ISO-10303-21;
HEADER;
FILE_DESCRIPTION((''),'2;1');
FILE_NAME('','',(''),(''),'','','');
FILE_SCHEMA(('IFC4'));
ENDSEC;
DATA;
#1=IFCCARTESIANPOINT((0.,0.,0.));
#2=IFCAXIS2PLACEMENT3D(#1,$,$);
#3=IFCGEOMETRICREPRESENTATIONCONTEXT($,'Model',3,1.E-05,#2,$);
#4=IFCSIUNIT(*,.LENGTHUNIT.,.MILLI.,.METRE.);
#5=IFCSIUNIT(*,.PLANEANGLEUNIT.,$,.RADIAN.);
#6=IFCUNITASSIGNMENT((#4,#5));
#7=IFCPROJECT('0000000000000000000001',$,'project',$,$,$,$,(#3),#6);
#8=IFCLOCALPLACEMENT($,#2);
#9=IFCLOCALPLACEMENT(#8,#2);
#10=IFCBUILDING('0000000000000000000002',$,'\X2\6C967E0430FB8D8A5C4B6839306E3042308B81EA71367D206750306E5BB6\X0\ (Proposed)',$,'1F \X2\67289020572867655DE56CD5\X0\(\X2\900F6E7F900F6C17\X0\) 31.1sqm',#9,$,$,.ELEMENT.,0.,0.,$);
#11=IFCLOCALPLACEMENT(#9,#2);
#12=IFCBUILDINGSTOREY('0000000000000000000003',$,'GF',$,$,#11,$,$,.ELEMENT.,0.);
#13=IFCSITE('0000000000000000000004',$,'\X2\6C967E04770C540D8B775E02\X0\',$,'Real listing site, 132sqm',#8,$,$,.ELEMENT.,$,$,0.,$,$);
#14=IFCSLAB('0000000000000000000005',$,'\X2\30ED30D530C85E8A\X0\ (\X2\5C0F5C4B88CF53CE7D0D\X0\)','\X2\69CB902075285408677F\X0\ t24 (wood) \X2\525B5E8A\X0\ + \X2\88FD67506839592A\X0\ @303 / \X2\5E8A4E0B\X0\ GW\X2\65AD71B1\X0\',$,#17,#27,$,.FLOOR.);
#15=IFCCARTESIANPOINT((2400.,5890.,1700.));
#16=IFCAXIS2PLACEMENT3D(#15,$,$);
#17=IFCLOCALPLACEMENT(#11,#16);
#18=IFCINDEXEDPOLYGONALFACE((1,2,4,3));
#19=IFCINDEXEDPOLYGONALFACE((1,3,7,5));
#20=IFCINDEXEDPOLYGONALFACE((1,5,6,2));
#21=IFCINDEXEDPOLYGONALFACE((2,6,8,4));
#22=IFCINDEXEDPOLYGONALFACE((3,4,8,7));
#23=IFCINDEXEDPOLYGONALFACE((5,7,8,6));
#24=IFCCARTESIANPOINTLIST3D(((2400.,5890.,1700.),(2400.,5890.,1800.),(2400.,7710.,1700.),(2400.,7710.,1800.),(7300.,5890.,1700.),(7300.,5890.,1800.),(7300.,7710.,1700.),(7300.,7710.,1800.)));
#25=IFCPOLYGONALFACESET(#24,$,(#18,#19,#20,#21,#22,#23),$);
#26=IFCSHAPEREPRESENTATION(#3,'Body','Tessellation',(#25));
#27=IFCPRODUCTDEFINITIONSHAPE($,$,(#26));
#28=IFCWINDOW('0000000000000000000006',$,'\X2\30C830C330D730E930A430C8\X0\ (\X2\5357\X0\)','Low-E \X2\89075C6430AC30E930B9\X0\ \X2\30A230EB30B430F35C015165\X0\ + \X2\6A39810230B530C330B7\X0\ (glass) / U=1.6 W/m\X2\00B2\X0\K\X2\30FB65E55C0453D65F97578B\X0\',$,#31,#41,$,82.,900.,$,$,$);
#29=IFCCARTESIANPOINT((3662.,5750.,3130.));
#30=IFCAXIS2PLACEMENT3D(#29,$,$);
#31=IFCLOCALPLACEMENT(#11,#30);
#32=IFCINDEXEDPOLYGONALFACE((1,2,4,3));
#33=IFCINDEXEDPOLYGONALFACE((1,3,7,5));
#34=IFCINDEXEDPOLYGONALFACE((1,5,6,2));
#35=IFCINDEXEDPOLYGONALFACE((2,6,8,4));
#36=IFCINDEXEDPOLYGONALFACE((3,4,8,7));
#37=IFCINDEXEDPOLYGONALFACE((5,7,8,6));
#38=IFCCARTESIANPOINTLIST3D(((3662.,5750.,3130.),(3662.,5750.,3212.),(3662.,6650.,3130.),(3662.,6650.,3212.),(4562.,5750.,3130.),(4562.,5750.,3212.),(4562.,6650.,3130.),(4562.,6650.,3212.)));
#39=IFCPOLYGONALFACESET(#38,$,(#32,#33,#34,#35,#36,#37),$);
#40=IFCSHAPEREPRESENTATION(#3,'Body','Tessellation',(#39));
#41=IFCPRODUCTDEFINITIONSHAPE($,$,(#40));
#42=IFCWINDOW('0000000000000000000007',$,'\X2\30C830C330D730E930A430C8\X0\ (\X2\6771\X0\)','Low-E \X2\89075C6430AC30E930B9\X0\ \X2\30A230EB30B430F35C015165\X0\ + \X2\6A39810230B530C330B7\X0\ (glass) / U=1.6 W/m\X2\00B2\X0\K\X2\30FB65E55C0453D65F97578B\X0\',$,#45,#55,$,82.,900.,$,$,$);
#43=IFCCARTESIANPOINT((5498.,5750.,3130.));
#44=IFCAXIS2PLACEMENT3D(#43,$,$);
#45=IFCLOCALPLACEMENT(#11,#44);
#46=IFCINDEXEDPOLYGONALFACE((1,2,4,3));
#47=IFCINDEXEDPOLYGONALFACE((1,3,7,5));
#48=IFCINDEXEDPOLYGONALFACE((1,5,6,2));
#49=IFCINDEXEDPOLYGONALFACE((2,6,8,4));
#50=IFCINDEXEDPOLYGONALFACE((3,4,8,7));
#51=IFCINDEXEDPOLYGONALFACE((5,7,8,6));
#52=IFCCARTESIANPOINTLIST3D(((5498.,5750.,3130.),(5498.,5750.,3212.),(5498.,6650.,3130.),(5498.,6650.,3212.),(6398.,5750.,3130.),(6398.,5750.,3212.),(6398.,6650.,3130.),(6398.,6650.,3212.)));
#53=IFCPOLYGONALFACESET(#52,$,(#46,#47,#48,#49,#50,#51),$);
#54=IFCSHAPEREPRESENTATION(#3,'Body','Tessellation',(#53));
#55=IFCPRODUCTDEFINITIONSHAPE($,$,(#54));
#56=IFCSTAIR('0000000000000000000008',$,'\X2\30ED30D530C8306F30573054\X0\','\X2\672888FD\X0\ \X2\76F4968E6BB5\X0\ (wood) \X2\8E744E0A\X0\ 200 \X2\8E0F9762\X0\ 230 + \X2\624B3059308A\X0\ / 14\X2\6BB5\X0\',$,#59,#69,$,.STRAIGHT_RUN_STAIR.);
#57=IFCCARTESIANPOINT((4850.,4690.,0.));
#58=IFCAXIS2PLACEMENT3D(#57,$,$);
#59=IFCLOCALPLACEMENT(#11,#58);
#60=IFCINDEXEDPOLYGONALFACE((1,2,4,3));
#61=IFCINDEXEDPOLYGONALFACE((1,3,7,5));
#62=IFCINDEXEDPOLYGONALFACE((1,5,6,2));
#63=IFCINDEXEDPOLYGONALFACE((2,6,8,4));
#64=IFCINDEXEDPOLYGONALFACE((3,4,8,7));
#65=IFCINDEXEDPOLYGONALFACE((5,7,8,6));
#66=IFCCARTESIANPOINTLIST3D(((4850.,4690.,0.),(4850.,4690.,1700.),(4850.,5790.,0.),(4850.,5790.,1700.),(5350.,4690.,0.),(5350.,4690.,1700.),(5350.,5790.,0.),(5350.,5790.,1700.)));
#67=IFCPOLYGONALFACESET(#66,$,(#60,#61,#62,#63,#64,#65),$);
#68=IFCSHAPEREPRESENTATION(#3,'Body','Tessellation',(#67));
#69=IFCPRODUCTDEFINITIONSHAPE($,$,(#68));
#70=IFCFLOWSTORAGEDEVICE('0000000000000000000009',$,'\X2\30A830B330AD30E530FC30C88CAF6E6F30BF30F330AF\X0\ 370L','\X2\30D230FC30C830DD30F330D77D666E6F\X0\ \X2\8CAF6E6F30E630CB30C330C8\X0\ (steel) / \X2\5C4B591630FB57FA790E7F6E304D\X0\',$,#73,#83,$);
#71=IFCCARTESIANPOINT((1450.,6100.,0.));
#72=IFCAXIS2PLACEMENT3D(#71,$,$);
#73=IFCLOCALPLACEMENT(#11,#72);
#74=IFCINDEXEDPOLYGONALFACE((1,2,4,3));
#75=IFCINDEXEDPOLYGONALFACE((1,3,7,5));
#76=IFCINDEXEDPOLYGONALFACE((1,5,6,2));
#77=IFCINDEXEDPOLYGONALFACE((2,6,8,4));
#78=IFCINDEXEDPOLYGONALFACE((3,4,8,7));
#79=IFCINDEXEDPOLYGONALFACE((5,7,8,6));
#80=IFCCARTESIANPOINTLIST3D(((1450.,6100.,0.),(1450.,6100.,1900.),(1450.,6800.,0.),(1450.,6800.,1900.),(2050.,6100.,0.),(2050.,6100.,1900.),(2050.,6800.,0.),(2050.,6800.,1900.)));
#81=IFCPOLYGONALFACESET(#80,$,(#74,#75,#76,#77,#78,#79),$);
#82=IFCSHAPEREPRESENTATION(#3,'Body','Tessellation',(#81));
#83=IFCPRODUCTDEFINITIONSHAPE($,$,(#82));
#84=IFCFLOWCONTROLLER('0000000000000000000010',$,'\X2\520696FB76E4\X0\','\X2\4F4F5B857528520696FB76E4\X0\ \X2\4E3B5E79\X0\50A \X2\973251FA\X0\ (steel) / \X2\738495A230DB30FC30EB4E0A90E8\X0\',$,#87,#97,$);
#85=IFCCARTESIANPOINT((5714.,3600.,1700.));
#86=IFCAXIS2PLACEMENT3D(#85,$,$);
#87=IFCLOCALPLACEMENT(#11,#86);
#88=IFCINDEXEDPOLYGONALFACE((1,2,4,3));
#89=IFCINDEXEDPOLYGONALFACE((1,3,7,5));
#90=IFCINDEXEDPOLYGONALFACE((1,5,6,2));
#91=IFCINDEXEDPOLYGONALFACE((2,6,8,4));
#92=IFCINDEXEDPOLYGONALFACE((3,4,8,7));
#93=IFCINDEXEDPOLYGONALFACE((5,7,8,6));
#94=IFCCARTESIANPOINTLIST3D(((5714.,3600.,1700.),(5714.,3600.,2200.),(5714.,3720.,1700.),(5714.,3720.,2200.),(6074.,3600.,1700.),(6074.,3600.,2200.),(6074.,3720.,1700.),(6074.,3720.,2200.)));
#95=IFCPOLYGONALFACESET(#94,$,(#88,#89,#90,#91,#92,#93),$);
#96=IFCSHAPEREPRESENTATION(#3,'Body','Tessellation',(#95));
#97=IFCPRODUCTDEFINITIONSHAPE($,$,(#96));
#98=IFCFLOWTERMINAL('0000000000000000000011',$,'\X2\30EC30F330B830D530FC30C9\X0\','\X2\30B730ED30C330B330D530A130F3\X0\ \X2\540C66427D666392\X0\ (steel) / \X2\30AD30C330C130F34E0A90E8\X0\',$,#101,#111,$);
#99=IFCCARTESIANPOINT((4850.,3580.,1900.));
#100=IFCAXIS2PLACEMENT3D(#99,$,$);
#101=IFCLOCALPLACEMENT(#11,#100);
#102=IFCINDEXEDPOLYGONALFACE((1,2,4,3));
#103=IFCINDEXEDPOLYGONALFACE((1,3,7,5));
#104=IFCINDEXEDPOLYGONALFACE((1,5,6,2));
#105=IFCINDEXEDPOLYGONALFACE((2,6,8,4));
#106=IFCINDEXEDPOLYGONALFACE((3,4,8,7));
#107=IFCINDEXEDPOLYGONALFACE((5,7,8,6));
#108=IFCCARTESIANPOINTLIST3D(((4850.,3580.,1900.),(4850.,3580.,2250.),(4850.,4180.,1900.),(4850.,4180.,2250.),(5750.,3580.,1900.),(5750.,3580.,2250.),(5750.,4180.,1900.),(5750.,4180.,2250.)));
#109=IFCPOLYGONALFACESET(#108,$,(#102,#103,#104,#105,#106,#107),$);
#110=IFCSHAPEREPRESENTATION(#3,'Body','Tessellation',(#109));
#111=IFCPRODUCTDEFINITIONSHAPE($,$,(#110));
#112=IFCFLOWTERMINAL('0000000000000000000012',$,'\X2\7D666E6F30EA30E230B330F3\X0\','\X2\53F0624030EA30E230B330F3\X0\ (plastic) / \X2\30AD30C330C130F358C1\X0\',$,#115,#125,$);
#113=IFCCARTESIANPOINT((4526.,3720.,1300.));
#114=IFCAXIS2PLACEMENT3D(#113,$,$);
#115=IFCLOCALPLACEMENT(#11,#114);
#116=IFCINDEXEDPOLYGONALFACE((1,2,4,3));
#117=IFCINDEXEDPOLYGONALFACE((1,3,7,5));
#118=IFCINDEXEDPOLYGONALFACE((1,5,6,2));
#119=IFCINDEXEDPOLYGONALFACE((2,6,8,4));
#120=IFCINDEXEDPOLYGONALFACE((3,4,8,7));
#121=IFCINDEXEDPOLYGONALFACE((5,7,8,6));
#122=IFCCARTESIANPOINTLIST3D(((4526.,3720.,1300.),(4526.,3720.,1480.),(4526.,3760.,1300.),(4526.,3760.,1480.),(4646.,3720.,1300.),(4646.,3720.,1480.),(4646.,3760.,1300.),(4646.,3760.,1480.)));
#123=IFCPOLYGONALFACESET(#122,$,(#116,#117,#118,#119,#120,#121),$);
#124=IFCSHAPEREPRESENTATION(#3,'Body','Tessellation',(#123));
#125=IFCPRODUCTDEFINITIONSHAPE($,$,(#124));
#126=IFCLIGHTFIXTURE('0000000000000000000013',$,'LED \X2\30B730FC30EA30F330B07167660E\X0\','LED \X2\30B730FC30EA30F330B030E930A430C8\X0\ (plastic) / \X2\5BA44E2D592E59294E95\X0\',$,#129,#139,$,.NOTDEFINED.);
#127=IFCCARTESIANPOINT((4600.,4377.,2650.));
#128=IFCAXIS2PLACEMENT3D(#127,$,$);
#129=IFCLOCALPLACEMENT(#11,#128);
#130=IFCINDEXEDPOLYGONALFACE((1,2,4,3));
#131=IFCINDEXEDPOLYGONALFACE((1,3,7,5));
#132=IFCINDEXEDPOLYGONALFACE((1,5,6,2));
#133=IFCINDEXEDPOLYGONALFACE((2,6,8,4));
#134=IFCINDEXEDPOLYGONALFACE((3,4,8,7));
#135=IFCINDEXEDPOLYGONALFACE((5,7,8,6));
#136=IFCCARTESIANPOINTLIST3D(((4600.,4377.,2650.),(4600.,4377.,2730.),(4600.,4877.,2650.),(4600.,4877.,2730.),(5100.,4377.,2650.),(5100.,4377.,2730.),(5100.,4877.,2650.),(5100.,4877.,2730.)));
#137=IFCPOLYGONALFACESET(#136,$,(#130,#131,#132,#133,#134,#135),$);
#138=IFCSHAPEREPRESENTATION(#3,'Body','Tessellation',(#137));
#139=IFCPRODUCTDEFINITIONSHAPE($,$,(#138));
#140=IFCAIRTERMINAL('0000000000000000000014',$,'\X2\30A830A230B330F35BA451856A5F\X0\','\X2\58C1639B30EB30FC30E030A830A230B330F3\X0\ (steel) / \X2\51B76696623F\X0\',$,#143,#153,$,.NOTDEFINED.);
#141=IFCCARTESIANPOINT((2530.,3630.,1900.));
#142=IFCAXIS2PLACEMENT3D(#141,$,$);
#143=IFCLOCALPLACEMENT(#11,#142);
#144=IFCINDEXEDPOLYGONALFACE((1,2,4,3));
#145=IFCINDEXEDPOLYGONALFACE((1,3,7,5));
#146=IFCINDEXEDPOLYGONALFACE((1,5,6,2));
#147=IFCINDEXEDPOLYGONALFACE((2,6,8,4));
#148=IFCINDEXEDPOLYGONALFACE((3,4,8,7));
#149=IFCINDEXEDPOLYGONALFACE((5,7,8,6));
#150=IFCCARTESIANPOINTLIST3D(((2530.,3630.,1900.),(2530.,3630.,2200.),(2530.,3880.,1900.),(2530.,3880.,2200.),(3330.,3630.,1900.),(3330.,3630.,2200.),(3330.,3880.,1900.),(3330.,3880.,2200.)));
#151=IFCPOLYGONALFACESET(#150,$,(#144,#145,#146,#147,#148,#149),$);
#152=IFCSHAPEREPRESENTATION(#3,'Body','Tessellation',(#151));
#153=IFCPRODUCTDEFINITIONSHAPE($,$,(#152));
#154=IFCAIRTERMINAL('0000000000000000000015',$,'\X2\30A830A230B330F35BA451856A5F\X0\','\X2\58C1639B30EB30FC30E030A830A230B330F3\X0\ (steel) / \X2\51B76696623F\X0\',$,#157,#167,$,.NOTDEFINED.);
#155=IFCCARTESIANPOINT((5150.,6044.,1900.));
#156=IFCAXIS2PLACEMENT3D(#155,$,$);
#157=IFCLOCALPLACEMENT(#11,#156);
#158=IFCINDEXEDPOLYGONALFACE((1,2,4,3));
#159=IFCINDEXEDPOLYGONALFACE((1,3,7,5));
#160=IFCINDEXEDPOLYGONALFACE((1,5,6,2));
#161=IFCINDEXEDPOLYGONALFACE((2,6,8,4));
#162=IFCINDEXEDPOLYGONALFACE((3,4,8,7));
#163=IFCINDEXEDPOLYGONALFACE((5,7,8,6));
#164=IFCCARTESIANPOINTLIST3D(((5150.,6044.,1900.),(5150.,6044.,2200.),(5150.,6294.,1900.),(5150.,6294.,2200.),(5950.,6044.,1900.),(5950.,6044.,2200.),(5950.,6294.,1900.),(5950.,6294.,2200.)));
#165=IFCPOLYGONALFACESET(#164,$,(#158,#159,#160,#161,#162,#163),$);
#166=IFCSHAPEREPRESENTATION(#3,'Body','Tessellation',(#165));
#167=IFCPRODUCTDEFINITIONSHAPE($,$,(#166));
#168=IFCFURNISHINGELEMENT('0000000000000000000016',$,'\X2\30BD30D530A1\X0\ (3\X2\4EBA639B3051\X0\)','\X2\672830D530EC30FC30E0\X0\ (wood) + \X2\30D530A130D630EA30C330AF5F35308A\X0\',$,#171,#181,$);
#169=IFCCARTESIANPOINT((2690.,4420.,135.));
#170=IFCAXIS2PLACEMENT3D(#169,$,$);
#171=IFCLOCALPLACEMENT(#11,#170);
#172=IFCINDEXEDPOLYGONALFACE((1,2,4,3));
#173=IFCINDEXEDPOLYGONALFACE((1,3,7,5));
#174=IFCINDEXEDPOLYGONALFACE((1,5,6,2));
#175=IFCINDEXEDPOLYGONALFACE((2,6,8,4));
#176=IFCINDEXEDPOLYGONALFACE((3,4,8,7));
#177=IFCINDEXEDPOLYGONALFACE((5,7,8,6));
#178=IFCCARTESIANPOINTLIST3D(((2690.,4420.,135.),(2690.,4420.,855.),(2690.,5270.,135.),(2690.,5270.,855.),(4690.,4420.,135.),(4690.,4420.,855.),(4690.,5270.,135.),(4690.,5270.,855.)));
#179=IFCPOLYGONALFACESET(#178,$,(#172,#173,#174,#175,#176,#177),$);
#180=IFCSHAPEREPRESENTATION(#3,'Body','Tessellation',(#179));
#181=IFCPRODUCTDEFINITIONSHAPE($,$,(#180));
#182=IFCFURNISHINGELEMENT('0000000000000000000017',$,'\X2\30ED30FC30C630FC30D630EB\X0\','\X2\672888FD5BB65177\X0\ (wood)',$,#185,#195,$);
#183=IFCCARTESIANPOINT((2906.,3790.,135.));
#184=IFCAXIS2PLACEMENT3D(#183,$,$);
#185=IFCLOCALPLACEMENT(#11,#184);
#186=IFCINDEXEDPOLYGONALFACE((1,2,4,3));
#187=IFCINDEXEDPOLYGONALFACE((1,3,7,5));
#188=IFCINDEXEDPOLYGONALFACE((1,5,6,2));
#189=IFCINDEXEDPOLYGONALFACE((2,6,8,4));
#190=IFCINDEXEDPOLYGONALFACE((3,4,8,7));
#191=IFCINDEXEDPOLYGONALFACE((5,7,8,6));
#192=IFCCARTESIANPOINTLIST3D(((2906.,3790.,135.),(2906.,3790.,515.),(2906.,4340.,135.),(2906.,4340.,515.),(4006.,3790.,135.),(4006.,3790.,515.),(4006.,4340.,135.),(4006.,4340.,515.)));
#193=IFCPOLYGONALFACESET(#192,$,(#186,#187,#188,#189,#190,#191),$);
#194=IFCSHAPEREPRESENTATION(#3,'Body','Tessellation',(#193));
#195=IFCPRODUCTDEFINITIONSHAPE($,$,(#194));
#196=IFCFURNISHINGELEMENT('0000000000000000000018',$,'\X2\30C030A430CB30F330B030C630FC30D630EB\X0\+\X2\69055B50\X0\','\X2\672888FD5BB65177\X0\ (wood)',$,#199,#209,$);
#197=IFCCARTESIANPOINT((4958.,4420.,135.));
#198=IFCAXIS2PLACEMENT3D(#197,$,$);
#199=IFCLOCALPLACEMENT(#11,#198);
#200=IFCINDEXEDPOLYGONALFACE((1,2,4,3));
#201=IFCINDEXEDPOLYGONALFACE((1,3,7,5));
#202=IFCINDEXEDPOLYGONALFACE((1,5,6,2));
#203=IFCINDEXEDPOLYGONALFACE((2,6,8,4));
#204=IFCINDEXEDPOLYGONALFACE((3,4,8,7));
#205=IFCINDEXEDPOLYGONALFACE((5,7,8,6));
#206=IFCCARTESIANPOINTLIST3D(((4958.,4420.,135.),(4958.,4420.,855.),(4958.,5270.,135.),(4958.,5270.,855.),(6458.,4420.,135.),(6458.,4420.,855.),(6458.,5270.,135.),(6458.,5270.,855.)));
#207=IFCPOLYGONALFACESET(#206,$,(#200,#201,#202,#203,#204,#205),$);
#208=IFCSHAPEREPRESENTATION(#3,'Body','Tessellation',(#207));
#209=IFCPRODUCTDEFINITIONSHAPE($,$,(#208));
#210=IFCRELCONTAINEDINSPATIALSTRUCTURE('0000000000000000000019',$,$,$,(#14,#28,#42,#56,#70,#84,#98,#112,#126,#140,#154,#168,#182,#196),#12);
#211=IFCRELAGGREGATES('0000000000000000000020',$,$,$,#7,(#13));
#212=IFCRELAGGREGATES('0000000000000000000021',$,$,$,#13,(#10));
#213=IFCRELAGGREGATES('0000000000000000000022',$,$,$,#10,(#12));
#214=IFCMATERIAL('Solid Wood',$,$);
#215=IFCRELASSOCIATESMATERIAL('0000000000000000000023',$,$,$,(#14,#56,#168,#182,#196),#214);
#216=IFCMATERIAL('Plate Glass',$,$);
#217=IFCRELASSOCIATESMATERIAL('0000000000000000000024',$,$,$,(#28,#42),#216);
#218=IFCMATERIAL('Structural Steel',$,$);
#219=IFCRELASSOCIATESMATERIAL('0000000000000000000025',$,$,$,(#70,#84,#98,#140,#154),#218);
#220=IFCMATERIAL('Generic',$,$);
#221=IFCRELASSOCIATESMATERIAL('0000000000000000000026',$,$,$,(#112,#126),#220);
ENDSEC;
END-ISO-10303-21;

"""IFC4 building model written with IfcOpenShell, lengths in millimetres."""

from ifc_helpers import new_model, si_unit, frame, frame_2d, origin, place, context, project, spatial, rectangle, extrude, material, element, save


model = new_model("IFC4")

# Units and contexts
model_context = context("Model", 3, precision=1e-05, world=origin())
ifc_project = project(units=[si_unit("LENGTHUNIT", "METRE", prefix="MILLI"), si_unit("PLANEANGLEUNIT", "RADIAN")], contexts=[model_context])

# Site, building, storey
site_placement = place(None, origin())
site = spatial("IfcSite", under=ifc_project, at=site_placement, Name="沖縄県名護市", ObjectType="Real listing site, 132sqm", CompositionType="ELEMENT", RefElevation=0.0)
building_placement = place(site_placement, origin())
building = spatial("IfcBuilding", under=site, at=building_placement, Name="沖縄・越屋根のある自然素材の家 (Proposed)", ObjectType="1F 木造在来工法(透湿透気) 31.1sqm", CompositionType="ELEMENT", ElevationOfRefHeight=0.0, ElevationOfTerrain=0.0)
storey_placement = place(building_placement, origin())
storey = spatial("IfcBuildingStorey", under=building, at=storey_placement, Name="GF", CompositionType="ELEMENT", Elevation=0.0)

# Shared definitions
ifc_material_1 = material(Name="Solid Wood")

# Slab
slab_placement = place(storey_placement, frame((2400.0, 5890.0, 1700.0)))
element("IfcSlab", 1, at=slab_placement, inside=storey, material=ifc_material_1, Name="ロフト床 (小屋裏収納)", Description="構造用合板 t24 (wood) 剛床 + 製材根太 @303 / 床下 GW断熱", PredefinedType="FLOOR", context=model_context, shape_type="SweptSolid", body=[
    extrude(rectangle(XDim=4900.0, YDim=1820.0, at=frame_2d((2450.0, 910.0))), frame((2400.0, 5890.0, 1700.0)), (0.0, 0.0, 1.0), 100.0),
])

# Windows
ifc_material_2 = material(Name="Plate Glass")
window_1_placement = place(storey_placement, frame((3662.0, 5750.0, 3130.0)))
element("IfcWindow", 2, at=window_1_placement, inside=storey, material=ifc_material_2, Name="トップライト (南)", Description="Low-E 複層ガラス アルゴン封入 + 樹脂サッシ (glass) / U=1.6 W/m²K・日射取得型", OverallHeight=82.0, OverallWidth=900.0, context=model_context, shape_type="SweptSolid", body=[
    extrude(rectangle(XDim=900.0, YDim=900.0, at=frame_2d((450.0, 450.0))), frame((3662.0, 5750.0, 3130.0)), (0.0, 0.0, 1.0), 82.0),
])
window_2_placement = place(storey_placement, frame((5498.0, 5750.0, 3130.0)))
element("IfcWindow", 3, at=window_2_placement, inside=storey, material=ifc_material_2, Name="トップライト (東)", Description="Low-E 複層ガラス アルゴン封入 + 樹脂サッシ (glass) / U=1.6 W/m²K・日射取得型", OverallHeight=82.0, OverallWidth=900.0, context=model_context, shape_type="SweptSolid", body=[
    extrude(rectangle(XDim=900.0, YDim=900.0, at=frame_2d((450.0, 450.0))), frame((5498.0, 5750.0, 3130.0)), (0.0, 0.0, 1.0), 82.0),
])

# Stair
stair_placement = place(storey_placement, frame((4850.0, 4690.0, 0.0)))
element("IfcStair", 4, at=stair_placement, inside=storey, material=ifc_material_1, Name="ロフトはしご", Description="木製 直階段 (wood) 蹴上 200 踏面 230 + 手すり / 14段", PredefinedType="STRAIGHT_RUN_STAIR", context=model_context, shape_type="SweptSolid", body=[
    extrude(rectangle(XDim=500.0, YDim=1100.0, at=frame_2d((250.0, 550.0))), frame((4850.0, 4690.0, 0.0)), (0.0, 0.0, 1.0), 1700.0),
])

# Flow storage device
ifc_material_3 = material(Name="Structural Steel")
flow_storage_device_placement = place(storey_placement, frame((1450.0, 6100.0, 0.0)))
element("IfcFlowStorageDevice", 5, at=flow_storage_device_placement, inside=storey, material=ifc_material_3, Name="エコキュート貯湯タンク 370L", Description="ヒートポンプ給湯 貯湯ユニット (steel) / 屋外・基礎置き", context=model_context, shape_type="SweptSolid", body=[
    extrude(rectangle(XDim=600.0, YDim=700.0, at=frame_2d((300.0, 350.0))), frame((1450.0, 6100.0, 0.0)), (0.0, 0.0, 1.0), 1900.0),
])

# Flow controller
flow_controller_placement = place(storey_placement, frame((5714.0, 3600.0, 1700.0)))
element("IfcFlowController", 6, at=flow_controller_placement, inside=storey, material=ifc_material_3, Name="分電盤", Description="住宅用分電盤 主幹50A 露出 (steel) / 玄関ホール上部", context=model_context, shape_type="SweptSolid", body=[
    extrude(rectangle(XDim=360.0, YDim=120.0, at=frame_2d((180.0, 60.0))), frame((5714.0, 3600.0, 1700.0)), (0.0, 0.0, 1.0), 500.0),
])

# Flow terminals
flow_terminal_1_placement = place(storey_placement, frame((4850.0, 3580.0, 1900.0)))
element("IfcFlowTerminal", 7, at=flow_terminal_1_placement, inside=storey, material=ifc_material_3, Name="レンジフード", Description="シロッコファン 同時給排 (steel) / キッチン上部", context=model_context, shape_type="SweptSolid", body=[
    extrude(rectangle(XDim=900.0, YDim=600.0, at=frame_2d((450.0, 300.0))), frame((4850.0, 3580.0, 1900.0)), (0.0, 0.0, 1.0), 350.0),
])
ifc_material_4 = material(Name="Generic")
flow_terminal_2_placement = place(storey_placement, frame((4526.0, 3720.0, 1300.0)))
element("IfcFlowTerminal", 8, at=flow_terminal_2_placement, inside=storey, material=ifc_material_4, Name="給湯リモコン", Description="台所リモコン (plastic) / キッチン壁", context=model_context, shape_type="SweptSolid", body=[
    extrude(rectangle(XDim=120.0, YDim=40.0, at=frame_2d((60.0, 20.0))), frame((4526.0, 3720.0, 1300.0)), (0.0, 0.0, 1.0), 180.0),
])

# Light fixture
light_fixture_placement = place(storey_placement, frame((4600.0, 4377.0, 2650.0)))
element("IfcLightFixture", 9, at=light_fixture_placement, inside=storey, material=ifc_material_4, Name="LED シーリング照明", Description="LED シーリングライト (plastic) / 室中央天井", PredefinedType="NOTDEFINED", context=model_context, shape_type="SweptSolid", body=[
    extrude(rectangle(XDim=500.0, YDim=500.0, at=frame_2d((250.0, 250.0))), frame((4600.0, 4377.0, 2650.0)), (0.0, 0.0, 1.0), 80.0),
])

# Air terminals
air_terminal_1_placement = place(storey_placement, frame((2530.0, 3630.0, 1900.0)))
element("IfcAirTerminal", 10, at=air_terminal_1_placement, inside=storey, material=ifc_material_3, Name="エアコン室内機", Description="壁掛ルームエアコン (steel) / 冷暖房", PredefinedType="NOTDEFINED", context=model_context, shape_type="SweptSolid", body=[
    extrude(rectangle(XDim=800.0, YDim=250.0, at=frame_2d((400.0, 125.0))), frame((2530.0, 3630.0, 1900.0)), (0.0, 0.0, 1.0), 300.0),
])
air_terminal_2_placement = place(storey_placement, frame((5150.0, 6044.0, 1900.0)))
element("IfcAirTerminal", 11, at=air_terminal_2_placement, inside=storey, material=ifc_material_3, Name="エアコン室内機", Description="壁掛ルームエアコン (steel) / 冷暖房", PredefinedType="NOTDEFINED", context=model_context, shape_type="SweptSolid", body=[
    extrude(rectangle(XDim=800.0, YDim=250.0, at=frame_2d((400.0, 125.0))), frame((5150.0, 6044.0, 1900.0)), (0.0, 0.0, 1.0), 300.0),
])

# Furnishing elements
furnishing_1_placement = place(storey_placement, frame((2690.0, 4420.0, 135.0)))
element("IfcFurnishingElement", 12, at=furnishing_1_placement, inside=storey, material=ifc_material_1, Name="ソファ (3人掛け)", Description="木フレーム (wood) + ファブリック張り", context=model_context, shape_type="SweptSolid", body=[
    extrude(rectangle(XDim=2000.0, YDim=850.0, at=frame_2d((1000.0, 425.0))), frame((2690.0, 4420.0, 135.0)), (0.0, 0.0, 1.0), 720.0),
])
furnishing_2_placement = place(storey_placement, frame((2906.0, 3790.0, 135.0)))
element("IfcFurnishingElement", 13, at=furnishing_2_placement, inside=storey, material=ifc_material_1, Name="ローテーブル", Description="木製家具 (wood)", context=model_context, shape_type="SweptSolid", body=[
    extrude(rectangle(XDim=1100.0, YDim=550.0, at=frame_2d((550.0, 275.0))), frame((2906.0, 3790.0, 135.0)), (0.0, 0.0, 1.0), 380.0),
])
furnishing_3_placement = place(storey_placement, frame((4958.0, 4420.0, 135.0)))
element("IfcFurnishingElement", 14, at=furnishing_3_placement, inside=storey, material=ifc_material_1, Name="ダイニングテーブル+椅子", Description="木製家具 (wood)", context=model_context, shape_type="SweptSolid", body=[
    extrude(rectangle(XDim=1500.0, YDim=850.0, at=frame_2d((750.0, 425.0))), frame((4958.0, 4420.0, 135.0)), (0.0, 0.0, 1.0), 720.0),
])

save(model, "model.ifc")
